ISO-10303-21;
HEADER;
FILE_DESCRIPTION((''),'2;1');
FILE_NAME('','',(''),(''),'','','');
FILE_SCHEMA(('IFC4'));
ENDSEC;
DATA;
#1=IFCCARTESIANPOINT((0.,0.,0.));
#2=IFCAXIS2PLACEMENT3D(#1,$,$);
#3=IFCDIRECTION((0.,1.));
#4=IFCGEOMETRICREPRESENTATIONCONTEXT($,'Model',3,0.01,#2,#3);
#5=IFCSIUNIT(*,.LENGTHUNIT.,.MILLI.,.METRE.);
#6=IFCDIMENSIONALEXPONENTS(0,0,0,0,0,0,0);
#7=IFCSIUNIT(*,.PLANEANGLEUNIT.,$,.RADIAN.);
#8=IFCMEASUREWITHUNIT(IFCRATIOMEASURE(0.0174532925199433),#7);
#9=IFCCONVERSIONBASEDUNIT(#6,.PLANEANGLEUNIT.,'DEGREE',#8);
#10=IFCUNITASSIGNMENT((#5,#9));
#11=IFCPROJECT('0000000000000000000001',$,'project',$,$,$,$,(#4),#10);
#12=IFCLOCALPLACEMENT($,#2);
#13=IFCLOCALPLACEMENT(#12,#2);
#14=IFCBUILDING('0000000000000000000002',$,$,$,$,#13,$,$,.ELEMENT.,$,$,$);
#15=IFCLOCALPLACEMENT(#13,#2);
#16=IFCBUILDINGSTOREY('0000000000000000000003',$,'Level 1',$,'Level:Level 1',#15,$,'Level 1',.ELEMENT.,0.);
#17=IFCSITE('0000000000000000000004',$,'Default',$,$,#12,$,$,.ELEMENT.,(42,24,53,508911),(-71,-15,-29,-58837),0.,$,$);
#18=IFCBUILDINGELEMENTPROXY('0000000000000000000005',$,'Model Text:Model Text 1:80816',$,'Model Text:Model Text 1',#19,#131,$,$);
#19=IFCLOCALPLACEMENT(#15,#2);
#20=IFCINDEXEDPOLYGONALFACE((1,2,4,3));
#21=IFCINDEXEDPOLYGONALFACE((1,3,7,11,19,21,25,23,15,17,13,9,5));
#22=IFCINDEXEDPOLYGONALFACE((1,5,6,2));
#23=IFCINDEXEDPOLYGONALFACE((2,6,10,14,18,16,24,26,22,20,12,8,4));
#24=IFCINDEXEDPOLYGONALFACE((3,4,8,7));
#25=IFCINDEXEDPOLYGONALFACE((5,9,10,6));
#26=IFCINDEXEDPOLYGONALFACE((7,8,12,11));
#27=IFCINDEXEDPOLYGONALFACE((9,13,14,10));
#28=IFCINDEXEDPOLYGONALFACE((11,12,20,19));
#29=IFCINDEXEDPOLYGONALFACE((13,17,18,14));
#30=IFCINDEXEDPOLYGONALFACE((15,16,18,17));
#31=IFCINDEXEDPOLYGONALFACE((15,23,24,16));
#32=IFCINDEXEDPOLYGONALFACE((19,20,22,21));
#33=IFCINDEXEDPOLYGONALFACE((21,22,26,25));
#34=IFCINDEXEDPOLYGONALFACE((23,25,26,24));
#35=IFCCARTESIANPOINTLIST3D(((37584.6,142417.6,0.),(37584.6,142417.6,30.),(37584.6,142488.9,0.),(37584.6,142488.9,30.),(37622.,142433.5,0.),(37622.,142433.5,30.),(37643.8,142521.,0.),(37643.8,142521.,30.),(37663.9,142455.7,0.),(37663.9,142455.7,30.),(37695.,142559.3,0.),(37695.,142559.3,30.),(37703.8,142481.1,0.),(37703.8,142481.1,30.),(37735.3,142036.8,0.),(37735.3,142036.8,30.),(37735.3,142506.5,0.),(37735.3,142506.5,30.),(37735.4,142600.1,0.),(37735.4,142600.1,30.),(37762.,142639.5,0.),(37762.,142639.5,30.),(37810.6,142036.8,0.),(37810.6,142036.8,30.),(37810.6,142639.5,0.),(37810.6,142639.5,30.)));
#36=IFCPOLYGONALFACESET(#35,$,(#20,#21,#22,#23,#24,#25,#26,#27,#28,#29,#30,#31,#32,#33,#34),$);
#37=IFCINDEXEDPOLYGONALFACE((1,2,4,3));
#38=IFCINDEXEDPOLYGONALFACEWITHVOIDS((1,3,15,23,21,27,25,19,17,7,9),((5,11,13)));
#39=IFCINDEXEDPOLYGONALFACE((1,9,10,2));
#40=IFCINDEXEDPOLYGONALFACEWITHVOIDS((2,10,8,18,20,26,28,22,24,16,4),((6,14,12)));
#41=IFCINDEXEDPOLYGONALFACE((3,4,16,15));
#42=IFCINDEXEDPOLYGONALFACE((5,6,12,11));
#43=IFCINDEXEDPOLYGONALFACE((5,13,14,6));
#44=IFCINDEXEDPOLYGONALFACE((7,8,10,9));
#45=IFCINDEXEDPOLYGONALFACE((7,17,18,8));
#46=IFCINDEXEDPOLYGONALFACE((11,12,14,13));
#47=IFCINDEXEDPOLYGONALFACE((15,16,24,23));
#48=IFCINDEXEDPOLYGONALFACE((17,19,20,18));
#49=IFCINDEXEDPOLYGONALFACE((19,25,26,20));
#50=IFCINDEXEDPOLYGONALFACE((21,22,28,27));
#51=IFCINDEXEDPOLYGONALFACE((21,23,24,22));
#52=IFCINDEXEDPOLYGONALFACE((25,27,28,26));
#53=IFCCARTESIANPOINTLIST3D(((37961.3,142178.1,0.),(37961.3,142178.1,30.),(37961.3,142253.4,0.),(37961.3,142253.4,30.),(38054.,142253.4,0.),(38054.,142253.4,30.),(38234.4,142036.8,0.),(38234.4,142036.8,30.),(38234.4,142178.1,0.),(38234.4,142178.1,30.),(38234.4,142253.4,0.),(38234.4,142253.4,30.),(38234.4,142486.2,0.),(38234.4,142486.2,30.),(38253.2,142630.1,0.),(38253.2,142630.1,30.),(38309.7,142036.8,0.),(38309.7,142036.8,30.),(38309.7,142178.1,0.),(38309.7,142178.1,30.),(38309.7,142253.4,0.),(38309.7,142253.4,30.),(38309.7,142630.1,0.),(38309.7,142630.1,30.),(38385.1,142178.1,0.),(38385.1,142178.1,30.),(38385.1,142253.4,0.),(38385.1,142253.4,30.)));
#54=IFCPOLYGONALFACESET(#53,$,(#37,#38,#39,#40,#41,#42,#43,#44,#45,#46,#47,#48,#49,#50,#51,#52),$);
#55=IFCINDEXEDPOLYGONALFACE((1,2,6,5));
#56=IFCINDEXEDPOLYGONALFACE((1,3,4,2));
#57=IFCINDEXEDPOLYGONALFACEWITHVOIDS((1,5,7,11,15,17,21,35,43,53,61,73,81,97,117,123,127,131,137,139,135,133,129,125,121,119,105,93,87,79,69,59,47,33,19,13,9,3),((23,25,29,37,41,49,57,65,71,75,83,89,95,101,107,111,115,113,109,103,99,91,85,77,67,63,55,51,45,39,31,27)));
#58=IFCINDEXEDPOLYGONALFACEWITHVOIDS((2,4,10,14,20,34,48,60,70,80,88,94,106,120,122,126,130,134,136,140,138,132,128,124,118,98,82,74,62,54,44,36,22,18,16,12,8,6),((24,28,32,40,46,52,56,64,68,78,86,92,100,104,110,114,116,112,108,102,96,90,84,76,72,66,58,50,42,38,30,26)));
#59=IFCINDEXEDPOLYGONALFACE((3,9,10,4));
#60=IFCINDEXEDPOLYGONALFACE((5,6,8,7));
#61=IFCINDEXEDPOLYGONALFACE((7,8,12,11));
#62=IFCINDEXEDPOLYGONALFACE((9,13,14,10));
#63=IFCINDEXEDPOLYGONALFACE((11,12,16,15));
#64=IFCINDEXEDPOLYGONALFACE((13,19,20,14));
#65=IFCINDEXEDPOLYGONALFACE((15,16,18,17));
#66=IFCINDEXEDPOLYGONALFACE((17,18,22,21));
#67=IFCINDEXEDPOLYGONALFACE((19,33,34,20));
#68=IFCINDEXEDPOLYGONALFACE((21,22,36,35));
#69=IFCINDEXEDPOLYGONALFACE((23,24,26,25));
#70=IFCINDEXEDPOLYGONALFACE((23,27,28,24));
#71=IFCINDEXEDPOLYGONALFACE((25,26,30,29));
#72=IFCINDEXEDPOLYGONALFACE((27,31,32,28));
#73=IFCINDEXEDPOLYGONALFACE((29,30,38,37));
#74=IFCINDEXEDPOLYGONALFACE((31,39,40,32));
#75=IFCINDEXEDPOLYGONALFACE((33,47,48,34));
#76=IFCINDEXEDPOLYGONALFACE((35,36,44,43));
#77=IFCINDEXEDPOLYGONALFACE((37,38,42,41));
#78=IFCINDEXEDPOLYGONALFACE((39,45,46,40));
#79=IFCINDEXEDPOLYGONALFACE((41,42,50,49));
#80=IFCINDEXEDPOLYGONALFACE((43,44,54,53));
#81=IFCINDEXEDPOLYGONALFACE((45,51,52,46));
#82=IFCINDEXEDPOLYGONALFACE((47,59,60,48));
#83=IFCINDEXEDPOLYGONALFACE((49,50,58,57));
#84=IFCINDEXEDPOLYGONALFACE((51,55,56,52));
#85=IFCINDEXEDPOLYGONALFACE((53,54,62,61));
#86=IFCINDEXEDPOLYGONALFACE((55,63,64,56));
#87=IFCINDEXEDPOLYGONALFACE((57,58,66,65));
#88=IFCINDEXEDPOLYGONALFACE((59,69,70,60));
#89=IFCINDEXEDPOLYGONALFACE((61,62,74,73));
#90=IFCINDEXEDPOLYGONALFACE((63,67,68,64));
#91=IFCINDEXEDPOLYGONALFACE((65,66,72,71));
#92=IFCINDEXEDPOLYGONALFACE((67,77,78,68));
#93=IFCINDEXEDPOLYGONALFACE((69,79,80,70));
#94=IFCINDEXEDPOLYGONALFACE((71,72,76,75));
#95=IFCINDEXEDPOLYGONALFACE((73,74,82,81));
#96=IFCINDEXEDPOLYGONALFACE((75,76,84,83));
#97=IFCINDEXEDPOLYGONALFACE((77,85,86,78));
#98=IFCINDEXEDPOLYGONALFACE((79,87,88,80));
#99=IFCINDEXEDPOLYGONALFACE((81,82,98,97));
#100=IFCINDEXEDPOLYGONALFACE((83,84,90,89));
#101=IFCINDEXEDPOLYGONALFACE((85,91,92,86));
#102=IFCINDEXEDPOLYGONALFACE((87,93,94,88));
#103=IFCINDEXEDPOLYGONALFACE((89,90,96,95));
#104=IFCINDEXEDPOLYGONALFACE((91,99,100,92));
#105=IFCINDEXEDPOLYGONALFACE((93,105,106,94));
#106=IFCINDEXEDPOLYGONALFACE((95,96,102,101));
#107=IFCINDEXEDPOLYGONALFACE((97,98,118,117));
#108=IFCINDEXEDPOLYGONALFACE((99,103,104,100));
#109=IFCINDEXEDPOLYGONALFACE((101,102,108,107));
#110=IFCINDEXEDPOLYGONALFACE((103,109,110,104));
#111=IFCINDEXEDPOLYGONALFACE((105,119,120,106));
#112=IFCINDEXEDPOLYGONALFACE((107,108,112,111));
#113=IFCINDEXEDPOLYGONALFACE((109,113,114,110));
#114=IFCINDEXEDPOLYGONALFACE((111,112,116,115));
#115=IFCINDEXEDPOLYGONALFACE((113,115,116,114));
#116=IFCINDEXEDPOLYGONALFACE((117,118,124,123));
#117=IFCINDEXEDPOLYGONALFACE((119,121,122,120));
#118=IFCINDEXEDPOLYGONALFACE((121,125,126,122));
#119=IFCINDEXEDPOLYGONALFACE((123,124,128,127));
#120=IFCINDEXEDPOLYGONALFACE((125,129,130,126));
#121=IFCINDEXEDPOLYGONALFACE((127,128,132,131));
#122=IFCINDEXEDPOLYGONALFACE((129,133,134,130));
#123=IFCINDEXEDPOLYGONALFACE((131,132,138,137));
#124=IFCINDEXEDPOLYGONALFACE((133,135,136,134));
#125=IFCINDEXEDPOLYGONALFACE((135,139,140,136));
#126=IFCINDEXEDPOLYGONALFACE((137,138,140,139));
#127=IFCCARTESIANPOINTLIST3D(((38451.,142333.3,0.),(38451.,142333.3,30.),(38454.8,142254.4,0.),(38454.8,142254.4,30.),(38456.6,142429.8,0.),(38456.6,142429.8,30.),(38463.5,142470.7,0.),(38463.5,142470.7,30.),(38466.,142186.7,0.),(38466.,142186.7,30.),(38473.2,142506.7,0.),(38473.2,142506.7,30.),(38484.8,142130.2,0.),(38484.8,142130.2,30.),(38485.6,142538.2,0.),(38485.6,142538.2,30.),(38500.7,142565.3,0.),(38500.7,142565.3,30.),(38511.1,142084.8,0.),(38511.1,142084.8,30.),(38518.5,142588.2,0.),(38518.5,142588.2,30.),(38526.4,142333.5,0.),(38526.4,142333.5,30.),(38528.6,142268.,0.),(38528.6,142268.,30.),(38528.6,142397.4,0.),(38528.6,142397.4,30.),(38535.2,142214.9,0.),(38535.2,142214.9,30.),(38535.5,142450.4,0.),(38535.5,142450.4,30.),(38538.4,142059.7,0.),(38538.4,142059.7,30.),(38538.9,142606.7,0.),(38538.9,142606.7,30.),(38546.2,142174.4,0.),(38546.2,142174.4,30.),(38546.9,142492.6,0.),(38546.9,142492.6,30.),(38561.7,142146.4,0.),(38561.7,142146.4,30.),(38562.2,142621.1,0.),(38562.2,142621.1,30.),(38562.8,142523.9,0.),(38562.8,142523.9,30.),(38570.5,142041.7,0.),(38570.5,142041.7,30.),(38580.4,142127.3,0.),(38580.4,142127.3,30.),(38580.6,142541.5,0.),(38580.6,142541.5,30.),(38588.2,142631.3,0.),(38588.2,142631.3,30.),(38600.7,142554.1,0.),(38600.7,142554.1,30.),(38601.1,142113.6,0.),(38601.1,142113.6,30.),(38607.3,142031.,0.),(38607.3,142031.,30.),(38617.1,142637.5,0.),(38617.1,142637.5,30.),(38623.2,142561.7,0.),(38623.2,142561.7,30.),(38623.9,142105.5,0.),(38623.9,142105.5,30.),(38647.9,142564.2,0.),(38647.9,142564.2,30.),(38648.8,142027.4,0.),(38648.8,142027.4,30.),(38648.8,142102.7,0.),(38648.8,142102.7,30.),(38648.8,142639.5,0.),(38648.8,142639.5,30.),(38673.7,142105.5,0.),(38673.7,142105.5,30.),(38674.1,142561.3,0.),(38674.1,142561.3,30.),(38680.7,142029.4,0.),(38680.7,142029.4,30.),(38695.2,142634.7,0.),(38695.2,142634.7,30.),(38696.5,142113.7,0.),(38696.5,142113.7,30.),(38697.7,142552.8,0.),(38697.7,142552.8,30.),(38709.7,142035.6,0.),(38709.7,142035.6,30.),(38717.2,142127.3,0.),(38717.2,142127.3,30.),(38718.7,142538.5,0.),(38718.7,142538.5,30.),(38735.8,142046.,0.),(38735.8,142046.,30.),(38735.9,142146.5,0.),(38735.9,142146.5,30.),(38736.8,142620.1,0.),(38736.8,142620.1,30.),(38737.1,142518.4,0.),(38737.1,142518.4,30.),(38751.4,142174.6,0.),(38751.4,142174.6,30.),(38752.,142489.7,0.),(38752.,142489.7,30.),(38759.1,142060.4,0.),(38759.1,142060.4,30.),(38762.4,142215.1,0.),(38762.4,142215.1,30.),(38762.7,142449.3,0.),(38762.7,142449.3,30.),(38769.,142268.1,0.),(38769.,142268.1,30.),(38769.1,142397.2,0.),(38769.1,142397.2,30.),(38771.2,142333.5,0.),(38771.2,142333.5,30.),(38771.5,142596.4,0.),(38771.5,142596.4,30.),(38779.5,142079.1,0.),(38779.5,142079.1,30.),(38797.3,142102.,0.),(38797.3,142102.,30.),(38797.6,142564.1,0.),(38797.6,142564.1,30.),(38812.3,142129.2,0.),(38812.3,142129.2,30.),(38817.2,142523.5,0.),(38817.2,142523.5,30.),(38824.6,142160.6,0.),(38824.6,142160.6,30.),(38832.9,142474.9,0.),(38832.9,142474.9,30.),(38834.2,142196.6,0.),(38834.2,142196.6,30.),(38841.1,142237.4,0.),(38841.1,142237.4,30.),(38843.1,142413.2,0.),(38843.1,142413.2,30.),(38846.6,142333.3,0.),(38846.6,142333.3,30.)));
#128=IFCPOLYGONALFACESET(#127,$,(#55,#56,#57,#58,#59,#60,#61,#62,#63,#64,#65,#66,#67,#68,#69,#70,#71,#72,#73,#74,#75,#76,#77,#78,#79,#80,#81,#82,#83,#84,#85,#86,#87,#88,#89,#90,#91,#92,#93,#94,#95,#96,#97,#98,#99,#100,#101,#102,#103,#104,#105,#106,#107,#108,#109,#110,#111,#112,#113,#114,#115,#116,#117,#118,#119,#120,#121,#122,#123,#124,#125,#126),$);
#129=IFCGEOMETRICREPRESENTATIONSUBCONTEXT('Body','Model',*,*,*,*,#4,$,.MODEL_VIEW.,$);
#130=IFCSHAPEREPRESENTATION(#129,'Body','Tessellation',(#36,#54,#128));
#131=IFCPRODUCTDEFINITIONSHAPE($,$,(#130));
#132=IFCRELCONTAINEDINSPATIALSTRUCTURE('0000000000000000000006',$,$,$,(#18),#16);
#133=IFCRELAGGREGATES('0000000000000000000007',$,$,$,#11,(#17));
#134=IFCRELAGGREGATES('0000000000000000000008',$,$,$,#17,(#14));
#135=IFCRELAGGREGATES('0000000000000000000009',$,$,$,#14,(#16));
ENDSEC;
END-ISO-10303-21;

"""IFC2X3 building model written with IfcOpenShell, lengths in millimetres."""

from ifc_helpers import new_model, entity, si_unit, converted_unit, direction, frame, origin, place, context, subcontext, project, spatial, polyline, outline, extrude, element, save


model = new_model("IFC2X3")

# Units and contexts
model_context = context("Model", 3, precision=0.01, world=origin(), true_north=direction((0.0, 1.0)))
body_context = subcontext(model_context, "Body", "Model", "MODEL_VIEW")
ifc_project = project(units=[si_unit("LENGTHUNIT", "METRE", prefix="MILLI"), converted_unit("PLANEANGLEUNIT", "DEGREE", entity("IfcRatioMeasure", 0.0174532925199433), si_unit("PLANEANGLEUNIT", "RADIAN"), dimensions=[0, 0, 0, 0, 0, 0, 0])], contexts=[model_context])

# Site, building, storey
site_placement = place(None, origin())
site = spatial("IfcSite", under=ifc_project, at=site_placement, Name="Default", CompositionType="ELEMENT", RefLatitude=(42, 24, 53, 508911), RefLongitude=(-71, -15, -29, -58837), RefElevation=0.0)
building_placement = place(site_placement, origin())
building = spatial("IfcBuilding", under=site, at=building_placement, CompositionType="ELEMENT")
storey_placement = place(building_placement, origin())
storey = spatial("IfcBuildingStorey", under=building, at=storey_placement, Name="Level 1", ObjectType="Level:Level 1", LongName="Level 1", CompositionType="ELEMENT", Elevation=0.0)

# Building element proxy
proxy_1_placement = place(storey_placement, origin())
element("IfcBuildingElementProxy", 1, at=proxy_1_placement, inside=storey, Name="Model Text:Model Text 1:80816", ObjectType="Model Text:Model Text 1", context=body_context, shape_type="SweptSolid", body=[
    extrude(outline(polyline([(-410.6, -111.6), (192.1, -111.6), (192.1, -63.1), (152.7, -36.4), (111.9, 4.0), (73.6, 55.2), (41.4, 114.4), (-29.8, 114.4), (-13.9, 77.0), (8.3, 35.1), (33.7, -4.8), (59.1, -36.3), (-410.6, -36.3), (-410.6, -111.6)])), frame((37699.0, 142447.4, 0.0), z_axis=(0.0, 0.0, 1.0), x_axis=(0.0, 1.0, 0.0)), (0.0, 0.0, 1.0), 30.0),
    extrude(outline(polyline([(-6.8, -218.3), (68.5, -218.3), (68.5, -77.1), (143.8, -77.1), (143.8, -1.7), (68.5, -1.7), (68.5, 375.0), (12.0, 375.0), (-280.0, -1.7), (-280.0, -77.1), (-6.8, -77.1), (-6.8, -218.3)]), holes=[polyline([(-6.8, -1.7), (-187.3, -1.7), (-6.8, 231.1), (-6.8, -1.7)])]), frame((38241.3, 142255.1, 0.0)), (0.0, 0.0, 1.0), 30.0),
    extrude(outline(polyline([(-10.6, -198.7), (68.3, -198.7), (136.5, -190.7), (193.9, -174.7), (240.5, -150.6), (266.9, -124.4), (286.3, -93.2), (298.8, -57.0), (304.3, -15.7), (303.8, 16.2), (299.0, 45.5), (289.9, 72.1), (276.6, 96.0), (258.9, 117.3), (236.9, 136.2), (210.4, 152.5), (179.6, 166.3), (144.1, 177.6), (103.7, 186.3), (8.2, 196.4), (-71.8, 196.7), (-134.0, 189.4), (-183.3, 176.1), (-224.7, 158.4), (-258.2, 133.9), (-283.5, 100.3), (-300.1, 59.5), (-307.1, 13.4), (-306.6, -18.4), (-301.8, -47.5), (-292.8, -74.0), (-279.6, -97.9), (-262.0, -119.2), (-240.0, -138.1), (-213.6, -154.5), (-182.8, -168.4), (-147.3, -179.8), (-106.7, -188.6), (-10.6, -198.7)]), holes=[polyline([(-7.2, -123.5), (-71.0, -118.2), (-123.6, -108.8), (-165.2, -95.4), (-195.7, -78.0), (-212.4, -59.4), (-224.1, -38.7), (-230.6, -15.9), (-231.9, 8.9), (-227.8, 35.0), (-218.1, 58.1), (-202.8, 78.4), (-182.0, 95.8), (-152.6, 109.4), (-111.7, 118.1), (-59.4, 122.0), (4.4, 121.1), (69.6, 115.8), (122.2, 106.7), (162.2, 93.7), (189.5, 77.0), (207.7, 57.4), (220.4, 36.0), (227.5, 12.8), (229.1, -12.1), (225.2, -36.8), (215.9, -59.2), (201.3, -79.3), (181.4, -97.1), (152.6, -111.2), (111.6, -120.3), (58.3, -124.4), (-7.2, -123.5)])]), frame((38650.0, 142332.1, 0.0), z_axis=(0.0, 0.0, 1.0), x_axis=(0.047515, -0.998871, 0.0)), (0.0, 0.0, 1.0), 30.0),
])

save(model, "model.ifc")
